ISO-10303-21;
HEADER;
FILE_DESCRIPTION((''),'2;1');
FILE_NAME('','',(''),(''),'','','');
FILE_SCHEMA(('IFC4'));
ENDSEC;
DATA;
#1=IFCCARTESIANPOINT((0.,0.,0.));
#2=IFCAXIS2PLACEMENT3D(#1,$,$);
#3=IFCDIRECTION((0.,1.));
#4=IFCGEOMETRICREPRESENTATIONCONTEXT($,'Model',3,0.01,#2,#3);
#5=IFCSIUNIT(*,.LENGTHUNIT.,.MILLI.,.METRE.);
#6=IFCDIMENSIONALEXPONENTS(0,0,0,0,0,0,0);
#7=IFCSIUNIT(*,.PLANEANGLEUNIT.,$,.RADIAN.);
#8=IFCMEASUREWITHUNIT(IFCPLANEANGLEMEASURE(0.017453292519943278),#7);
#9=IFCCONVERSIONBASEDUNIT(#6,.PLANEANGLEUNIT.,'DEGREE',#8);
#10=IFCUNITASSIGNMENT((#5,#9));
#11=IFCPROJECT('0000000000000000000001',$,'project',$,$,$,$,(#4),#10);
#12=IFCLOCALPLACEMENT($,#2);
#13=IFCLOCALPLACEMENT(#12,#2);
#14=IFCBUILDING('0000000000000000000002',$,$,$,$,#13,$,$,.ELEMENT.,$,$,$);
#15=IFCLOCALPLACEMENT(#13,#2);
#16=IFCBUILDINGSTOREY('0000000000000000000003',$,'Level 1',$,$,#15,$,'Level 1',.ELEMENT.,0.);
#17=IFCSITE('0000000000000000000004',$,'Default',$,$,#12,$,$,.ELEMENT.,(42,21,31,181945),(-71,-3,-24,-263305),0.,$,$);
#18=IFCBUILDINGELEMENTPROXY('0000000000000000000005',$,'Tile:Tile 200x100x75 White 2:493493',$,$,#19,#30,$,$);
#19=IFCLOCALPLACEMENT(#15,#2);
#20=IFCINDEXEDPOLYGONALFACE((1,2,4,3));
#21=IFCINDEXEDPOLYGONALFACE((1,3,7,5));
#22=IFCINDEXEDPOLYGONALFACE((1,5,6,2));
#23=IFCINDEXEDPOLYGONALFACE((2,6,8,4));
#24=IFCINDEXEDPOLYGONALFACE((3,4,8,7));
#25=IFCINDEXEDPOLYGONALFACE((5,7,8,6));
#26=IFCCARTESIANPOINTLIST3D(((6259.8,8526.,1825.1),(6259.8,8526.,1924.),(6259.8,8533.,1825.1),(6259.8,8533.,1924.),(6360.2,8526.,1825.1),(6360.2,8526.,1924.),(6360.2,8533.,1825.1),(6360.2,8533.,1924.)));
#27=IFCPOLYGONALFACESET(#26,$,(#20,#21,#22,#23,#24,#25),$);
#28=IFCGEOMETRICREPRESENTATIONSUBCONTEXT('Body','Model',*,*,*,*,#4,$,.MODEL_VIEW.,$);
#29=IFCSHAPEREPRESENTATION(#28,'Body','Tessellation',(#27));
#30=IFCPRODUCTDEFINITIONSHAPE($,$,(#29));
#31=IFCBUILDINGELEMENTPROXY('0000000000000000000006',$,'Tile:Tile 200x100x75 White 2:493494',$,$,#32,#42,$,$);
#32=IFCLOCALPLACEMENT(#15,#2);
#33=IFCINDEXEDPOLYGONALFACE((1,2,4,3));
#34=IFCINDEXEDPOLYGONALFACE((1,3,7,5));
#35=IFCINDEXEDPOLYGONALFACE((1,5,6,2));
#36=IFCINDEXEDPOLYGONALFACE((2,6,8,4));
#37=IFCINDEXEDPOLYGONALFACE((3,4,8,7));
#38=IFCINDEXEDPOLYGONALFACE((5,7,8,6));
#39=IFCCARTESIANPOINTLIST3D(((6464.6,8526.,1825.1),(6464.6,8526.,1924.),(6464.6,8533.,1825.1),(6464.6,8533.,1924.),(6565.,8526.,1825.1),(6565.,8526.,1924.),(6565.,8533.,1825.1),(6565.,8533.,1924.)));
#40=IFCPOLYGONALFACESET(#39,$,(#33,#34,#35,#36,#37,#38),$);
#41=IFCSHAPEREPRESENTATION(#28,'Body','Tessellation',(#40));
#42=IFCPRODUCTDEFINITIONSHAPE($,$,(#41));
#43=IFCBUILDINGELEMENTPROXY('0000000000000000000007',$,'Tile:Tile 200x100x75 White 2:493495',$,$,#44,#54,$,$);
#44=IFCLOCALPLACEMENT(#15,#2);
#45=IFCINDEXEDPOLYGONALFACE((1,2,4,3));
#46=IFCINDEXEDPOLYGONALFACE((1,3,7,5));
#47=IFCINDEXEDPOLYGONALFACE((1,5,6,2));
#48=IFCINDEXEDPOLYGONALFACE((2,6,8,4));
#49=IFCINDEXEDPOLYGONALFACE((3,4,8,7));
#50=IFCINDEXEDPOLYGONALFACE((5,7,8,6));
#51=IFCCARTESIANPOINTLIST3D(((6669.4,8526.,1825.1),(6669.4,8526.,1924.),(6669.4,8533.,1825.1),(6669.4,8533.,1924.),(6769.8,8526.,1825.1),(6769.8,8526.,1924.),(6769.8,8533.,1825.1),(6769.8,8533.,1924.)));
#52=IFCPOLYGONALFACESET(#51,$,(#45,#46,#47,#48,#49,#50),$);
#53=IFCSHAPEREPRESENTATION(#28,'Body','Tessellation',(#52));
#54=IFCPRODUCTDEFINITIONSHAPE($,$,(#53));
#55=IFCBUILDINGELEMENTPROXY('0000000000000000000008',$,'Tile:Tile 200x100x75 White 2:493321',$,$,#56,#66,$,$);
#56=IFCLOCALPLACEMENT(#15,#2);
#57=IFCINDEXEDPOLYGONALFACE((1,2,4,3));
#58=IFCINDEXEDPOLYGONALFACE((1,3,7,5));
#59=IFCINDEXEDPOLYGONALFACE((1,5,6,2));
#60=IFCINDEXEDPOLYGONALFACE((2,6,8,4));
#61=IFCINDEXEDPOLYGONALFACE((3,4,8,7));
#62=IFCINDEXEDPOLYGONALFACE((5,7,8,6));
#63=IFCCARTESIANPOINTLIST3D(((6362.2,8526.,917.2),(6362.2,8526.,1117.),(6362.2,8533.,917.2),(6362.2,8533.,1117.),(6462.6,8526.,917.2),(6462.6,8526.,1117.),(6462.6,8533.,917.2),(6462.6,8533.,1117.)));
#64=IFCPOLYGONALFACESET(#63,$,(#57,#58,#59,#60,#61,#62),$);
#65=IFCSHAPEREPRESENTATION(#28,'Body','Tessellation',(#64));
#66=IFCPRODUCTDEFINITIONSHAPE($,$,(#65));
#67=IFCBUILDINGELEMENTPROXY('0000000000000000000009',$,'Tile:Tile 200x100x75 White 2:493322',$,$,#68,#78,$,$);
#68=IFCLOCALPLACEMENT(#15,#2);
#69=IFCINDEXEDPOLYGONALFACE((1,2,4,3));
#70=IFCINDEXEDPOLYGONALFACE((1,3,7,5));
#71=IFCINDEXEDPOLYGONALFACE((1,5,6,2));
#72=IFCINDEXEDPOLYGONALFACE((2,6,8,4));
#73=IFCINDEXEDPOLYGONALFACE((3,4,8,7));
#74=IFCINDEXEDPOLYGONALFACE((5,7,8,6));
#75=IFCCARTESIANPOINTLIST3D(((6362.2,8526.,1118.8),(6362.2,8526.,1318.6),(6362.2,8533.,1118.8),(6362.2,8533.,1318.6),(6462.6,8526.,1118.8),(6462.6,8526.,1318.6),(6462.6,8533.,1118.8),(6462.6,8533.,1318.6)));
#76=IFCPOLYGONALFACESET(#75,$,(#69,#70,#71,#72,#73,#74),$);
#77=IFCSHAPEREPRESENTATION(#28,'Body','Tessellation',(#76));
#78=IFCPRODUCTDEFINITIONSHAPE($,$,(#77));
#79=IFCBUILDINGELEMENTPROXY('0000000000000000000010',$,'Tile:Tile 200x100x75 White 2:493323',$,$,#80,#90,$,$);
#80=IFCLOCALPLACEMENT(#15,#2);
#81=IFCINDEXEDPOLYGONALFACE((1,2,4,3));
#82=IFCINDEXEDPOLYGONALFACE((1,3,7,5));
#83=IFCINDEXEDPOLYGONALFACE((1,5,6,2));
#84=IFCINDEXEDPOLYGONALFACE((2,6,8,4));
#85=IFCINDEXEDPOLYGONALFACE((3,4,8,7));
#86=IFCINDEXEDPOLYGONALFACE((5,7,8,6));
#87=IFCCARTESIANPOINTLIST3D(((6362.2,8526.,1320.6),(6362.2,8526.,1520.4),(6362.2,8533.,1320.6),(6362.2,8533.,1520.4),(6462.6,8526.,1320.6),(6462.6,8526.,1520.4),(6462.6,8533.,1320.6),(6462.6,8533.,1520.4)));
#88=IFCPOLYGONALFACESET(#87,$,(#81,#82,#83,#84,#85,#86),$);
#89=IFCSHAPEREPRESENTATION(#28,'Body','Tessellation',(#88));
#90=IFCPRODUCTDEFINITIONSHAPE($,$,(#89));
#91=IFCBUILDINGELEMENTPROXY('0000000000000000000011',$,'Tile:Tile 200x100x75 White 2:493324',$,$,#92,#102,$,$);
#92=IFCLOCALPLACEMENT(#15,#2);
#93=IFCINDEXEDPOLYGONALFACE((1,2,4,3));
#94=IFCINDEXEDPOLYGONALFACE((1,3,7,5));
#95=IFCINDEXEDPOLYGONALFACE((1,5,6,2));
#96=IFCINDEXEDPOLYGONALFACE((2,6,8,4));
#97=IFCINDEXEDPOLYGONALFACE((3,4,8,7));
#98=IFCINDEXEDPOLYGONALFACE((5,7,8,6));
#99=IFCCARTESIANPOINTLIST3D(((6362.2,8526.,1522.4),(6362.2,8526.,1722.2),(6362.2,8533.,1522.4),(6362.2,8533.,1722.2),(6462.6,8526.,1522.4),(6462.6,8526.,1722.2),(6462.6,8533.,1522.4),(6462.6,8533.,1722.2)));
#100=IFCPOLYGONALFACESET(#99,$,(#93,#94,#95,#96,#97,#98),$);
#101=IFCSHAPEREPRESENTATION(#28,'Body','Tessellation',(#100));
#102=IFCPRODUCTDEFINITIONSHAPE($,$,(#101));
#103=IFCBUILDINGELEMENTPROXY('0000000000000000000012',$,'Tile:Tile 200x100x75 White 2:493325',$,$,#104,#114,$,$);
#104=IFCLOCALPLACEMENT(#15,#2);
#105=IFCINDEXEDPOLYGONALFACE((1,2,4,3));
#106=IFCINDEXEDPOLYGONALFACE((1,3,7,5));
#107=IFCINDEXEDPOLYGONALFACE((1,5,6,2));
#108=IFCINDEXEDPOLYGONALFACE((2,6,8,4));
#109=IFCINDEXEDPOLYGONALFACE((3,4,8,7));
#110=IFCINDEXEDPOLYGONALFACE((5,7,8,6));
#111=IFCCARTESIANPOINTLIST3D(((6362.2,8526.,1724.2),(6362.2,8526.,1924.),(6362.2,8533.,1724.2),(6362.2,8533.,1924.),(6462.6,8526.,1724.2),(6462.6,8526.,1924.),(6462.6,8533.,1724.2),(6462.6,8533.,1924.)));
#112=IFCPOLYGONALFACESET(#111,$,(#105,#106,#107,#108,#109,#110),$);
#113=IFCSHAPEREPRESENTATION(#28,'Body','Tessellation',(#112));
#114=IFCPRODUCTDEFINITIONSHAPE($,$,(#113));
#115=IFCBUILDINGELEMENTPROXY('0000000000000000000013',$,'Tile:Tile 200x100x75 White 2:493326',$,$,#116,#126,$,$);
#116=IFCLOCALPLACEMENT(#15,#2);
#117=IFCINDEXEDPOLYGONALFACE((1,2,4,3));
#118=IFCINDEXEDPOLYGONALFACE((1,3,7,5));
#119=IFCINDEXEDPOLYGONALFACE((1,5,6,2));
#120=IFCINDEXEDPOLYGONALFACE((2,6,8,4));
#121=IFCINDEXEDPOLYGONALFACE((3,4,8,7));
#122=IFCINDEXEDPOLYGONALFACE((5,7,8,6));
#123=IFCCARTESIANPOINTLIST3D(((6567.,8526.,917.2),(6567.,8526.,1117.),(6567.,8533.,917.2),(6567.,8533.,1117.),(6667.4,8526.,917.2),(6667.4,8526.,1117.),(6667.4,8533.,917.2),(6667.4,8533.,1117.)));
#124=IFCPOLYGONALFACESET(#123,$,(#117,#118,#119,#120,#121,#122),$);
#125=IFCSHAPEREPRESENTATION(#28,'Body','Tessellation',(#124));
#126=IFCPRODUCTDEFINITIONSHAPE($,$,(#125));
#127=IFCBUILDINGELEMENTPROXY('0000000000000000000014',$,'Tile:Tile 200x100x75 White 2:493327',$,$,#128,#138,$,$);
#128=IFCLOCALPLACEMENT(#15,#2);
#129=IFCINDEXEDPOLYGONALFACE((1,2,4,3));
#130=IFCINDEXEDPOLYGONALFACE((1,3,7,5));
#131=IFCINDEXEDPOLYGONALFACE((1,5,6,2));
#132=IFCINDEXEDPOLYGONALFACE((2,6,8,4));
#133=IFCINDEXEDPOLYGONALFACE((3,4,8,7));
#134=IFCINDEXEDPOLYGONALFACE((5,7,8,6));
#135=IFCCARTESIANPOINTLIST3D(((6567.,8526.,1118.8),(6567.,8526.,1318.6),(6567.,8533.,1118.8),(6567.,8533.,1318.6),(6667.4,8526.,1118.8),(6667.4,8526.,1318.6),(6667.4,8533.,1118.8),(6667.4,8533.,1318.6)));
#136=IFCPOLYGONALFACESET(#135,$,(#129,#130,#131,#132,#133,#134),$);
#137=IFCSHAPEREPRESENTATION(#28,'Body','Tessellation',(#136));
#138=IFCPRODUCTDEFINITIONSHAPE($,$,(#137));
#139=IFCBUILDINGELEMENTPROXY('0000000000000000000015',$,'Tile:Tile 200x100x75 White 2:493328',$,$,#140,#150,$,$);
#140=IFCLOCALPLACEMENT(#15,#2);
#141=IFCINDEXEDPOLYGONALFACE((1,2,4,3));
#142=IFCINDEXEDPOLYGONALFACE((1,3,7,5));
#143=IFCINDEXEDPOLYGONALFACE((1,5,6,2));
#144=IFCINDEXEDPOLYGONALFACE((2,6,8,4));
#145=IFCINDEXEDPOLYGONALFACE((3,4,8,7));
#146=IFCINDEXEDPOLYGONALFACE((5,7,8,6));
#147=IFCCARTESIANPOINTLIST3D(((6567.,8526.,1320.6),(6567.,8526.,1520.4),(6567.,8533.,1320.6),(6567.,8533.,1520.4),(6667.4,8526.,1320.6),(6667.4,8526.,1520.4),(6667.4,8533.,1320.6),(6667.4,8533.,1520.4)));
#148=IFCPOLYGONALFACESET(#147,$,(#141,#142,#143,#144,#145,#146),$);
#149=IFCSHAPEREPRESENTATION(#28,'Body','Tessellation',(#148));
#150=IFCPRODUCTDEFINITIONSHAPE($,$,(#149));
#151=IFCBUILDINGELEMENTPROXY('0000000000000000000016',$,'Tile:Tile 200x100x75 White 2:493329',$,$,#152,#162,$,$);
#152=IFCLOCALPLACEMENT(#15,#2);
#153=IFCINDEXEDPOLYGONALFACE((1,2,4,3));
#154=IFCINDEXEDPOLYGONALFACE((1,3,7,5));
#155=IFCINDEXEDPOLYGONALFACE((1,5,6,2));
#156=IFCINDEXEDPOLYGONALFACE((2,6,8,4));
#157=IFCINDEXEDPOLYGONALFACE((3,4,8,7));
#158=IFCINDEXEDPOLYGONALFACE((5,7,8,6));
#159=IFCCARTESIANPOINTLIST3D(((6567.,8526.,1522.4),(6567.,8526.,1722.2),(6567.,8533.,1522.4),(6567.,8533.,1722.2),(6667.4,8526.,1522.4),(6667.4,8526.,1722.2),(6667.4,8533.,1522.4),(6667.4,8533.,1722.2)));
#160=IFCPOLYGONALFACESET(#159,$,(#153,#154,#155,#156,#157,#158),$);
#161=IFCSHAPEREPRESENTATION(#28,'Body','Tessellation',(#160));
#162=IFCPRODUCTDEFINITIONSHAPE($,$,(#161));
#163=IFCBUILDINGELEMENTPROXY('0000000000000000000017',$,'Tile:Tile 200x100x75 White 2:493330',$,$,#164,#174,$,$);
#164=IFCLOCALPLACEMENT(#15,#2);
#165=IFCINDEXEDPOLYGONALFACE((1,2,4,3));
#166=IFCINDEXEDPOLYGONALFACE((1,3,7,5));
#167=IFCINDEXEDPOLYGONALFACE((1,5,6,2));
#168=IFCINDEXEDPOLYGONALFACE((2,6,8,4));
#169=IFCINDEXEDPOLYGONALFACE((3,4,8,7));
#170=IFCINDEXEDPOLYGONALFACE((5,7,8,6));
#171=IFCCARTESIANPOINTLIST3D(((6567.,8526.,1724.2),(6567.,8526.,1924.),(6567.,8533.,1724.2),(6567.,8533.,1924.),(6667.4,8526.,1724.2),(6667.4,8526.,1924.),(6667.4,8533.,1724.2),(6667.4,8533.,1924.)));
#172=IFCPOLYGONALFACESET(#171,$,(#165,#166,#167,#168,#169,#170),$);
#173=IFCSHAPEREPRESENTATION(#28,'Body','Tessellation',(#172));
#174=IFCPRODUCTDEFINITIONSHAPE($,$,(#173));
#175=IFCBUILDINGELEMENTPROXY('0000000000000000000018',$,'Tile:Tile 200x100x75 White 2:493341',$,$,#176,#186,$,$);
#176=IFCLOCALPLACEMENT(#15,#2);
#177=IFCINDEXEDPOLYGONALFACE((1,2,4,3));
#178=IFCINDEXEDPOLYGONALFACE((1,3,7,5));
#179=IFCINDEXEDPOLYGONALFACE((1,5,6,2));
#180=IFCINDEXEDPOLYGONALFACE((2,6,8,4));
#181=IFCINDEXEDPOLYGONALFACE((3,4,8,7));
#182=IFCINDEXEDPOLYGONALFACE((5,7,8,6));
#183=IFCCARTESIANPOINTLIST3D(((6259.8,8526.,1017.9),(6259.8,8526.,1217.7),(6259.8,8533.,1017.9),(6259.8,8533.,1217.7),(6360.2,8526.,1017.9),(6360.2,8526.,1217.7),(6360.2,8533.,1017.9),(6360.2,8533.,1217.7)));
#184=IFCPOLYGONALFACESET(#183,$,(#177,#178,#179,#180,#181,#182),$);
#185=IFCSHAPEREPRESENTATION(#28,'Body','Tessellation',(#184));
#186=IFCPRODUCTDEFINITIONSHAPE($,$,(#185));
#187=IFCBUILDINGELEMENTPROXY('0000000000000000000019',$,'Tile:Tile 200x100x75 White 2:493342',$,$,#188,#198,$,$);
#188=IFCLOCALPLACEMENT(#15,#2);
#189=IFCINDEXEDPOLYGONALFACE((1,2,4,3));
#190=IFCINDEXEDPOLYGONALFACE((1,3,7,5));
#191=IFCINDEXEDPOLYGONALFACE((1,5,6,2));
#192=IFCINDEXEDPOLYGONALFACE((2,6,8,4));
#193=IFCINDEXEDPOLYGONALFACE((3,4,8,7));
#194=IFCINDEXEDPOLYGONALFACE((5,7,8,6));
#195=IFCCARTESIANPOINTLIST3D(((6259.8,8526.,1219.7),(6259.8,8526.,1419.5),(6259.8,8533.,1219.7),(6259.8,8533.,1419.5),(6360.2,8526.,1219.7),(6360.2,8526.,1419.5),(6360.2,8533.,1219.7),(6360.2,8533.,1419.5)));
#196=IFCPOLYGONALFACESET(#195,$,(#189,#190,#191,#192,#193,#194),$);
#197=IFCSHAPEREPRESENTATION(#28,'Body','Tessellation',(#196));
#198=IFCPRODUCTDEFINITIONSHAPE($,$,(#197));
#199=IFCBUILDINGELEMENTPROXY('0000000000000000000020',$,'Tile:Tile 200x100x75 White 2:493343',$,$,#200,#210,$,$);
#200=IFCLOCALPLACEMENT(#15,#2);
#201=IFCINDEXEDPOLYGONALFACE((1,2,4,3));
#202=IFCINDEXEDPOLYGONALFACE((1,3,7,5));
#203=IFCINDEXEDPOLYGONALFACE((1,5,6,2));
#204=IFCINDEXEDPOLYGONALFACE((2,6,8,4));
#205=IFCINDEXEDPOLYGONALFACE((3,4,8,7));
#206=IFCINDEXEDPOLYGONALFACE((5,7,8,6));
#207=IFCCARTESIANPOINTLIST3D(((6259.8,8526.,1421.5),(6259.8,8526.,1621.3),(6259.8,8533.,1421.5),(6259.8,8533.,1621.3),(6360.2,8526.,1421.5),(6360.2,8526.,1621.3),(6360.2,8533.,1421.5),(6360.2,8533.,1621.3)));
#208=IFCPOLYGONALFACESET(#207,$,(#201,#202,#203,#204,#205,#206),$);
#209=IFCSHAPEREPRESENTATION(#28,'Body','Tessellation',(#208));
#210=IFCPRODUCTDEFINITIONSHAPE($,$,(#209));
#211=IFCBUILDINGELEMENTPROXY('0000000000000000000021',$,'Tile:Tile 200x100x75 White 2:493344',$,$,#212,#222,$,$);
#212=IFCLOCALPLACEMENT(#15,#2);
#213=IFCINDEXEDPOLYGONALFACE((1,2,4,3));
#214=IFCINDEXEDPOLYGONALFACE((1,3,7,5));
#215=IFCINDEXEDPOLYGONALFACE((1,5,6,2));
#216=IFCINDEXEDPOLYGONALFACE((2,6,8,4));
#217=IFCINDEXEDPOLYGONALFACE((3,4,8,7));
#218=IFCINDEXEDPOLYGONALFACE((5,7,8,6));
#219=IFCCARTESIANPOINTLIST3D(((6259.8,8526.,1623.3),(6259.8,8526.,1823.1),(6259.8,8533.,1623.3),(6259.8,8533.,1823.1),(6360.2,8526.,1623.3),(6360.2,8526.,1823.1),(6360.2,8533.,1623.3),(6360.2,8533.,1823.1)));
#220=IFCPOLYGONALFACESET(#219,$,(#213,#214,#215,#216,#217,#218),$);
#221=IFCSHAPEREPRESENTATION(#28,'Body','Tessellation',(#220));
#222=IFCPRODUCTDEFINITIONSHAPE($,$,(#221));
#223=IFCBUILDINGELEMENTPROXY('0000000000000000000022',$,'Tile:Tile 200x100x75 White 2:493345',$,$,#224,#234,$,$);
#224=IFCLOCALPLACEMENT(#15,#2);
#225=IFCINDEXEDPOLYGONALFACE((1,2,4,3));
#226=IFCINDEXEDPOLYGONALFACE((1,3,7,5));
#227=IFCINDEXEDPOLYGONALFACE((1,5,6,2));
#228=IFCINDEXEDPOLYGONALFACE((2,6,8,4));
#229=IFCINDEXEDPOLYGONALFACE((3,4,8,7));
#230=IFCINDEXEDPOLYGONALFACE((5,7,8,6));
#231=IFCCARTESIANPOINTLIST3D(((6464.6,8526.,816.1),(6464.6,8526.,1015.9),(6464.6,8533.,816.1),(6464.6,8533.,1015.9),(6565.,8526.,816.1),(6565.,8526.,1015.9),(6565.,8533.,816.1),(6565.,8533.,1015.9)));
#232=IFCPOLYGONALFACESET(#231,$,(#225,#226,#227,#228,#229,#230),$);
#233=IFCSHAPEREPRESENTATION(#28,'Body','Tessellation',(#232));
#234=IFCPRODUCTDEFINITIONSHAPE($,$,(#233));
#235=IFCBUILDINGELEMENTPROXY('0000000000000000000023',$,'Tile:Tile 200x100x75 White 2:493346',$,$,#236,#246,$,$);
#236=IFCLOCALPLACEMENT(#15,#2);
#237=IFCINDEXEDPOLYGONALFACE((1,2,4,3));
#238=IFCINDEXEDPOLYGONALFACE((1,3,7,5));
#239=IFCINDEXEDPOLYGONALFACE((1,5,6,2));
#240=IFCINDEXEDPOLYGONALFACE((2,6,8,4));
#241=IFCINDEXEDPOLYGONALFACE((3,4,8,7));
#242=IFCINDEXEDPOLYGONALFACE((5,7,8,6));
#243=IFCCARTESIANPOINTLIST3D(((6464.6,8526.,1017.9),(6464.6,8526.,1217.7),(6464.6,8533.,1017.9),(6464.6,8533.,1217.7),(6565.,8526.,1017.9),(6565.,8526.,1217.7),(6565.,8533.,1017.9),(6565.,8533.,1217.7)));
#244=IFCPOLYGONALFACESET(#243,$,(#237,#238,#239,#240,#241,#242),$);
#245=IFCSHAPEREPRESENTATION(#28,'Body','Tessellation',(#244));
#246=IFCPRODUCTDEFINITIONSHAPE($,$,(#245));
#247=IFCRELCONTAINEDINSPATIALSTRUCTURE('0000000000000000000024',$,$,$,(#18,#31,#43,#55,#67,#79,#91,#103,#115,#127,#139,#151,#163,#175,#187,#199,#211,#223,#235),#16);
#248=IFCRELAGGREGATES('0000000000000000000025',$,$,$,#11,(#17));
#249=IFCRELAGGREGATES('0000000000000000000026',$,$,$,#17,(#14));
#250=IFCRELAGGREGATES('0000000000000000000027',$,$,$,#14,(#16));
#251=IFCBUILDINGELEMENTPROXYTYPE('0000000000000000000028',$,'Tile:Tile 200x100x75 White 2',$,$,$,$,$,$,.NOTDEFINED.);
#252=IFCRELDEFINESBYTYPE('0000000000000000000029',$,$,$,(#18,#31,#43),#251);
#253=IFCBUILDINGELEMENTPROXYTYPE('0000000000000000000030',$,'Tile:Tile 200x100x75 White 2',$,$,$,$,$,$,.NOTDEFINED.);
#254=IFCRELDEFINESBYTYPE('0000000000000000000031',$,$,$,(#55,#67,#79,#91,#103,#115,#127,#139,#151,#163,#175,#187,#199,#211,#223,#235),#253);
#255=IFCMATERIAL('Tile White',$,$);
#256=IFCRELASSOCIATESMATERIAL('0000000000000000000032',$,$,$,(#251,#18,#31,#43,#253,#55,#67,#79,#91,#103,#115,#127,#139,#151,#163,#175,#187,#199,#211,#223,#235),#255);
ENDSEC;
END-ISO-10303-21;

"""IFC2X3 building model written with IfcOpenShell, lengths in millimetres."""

from ifc_helpers import new_model, entity, si_unit, converted_unit, direction, frame, frame_2d, origin, origin_2d_with_axis, place, context, subcontext, project, spatial, rectangle, extrude, source, transform, mapped, material, type_object, type_shapes, element, save


model = new_model("IFC2X3")

# Units and contexts
model_context = context("Model", 3, precision=0.01, world=origin(), true_north=direction((0.0, 1.0)))
body_context = subcontext(model_context, "Body", "Model", "MODEL_VIEW")
ifc_project = project(units=[si_unit("LENGTHUNIT", "METRE", prefix="MILLI"), converted_unit("PLANEANGLEUNIT", "DEGREE", entity("IfcPlaneAngleMeasure", 0.017453292519943278), si_unit("PLANEANGLEUNIT", "RADIAN"), dimensions=[0, 0, 0, 0, 0, 0, 0])], contexts=[model_context])

# Site, building, storey
site_placement = place(None, origin())
site = spatial("IfcSite", under=ifc_project, at=site_placement, Name="Default", CompositionType="ELEMENT", RefLatitude=(42, 21, 31, 181945), RefLongitude=(-71, -3, -24, -263305), RefElevation=0.0)
building_placement = place(site_placement, origin())
building = spatial("IfcBuilding", under=site, at=building_placement, CompositionType="ELEMENT")
storey_placement = place(building_placement, origin())
storey = spatial("IfcBuildingStorey", under=building, at=storey_placement, Name="Level 1", LongName="Level 1", CompositionType="ELEMENT", Elevation=0.0)

# Building element proxies
ifc_material = material(Name="Tile White")
building_element_proxy_type_1 = type_object("IfcBuildingElementProxyType", Name="Tile:Tile 200x100x75 White 2", PredefinedType="NOTDEFINED", material=ifc_material)
shared_shape_1 = source(origin(), body_context, "Body", "SweptSolid", [
    extrude(rectangle(XDim=98.9, YDim=100.4, at=origin_2d_with_axis()), frame((-50.2, -49.5, 0.0), z_axis=(0.0, 0.0, 1.0), x_axis=(0.0, -1.0, 0.0)), (0.0, 0.0, 1.0), 7.0),
])
type_shapes(building_element_proxy_type_1, [shared_shape_1])
for number, where, z_axis, x_axis, name in (
    (1, (6360.2, 8533.0, 1924.0), (0.0, -1.0, 0.0), (1.0, 0.0, 0.0), "Tile:Tile 200x100x75 White 2:493493"),
    (2, (6565.0, 8533.0, 1924.0), (0.0, -1.0, 0.0), (1.0, 0.0, 0.0), "Tile:Tile 200x100x75 White 2:493494"),
    (3, (6769.8, 8533.0, 1924.0), (0.0, -1.0, 0.0), (1.0, 0.0, 0.0), "Tile:Tile 200x100x75 White 2:493495"),
):
    element("IfcBuildingElementProxy", number, at=place(storey_placement, frame(where, z_axis=z_axis, x_axis=x_axis)), inside=storey, type_object=building_element_proxy_type_1, material=ifc_material, Name=name, context=body_context, shape_type="MappedRepresentation", body=[
        mapped(shared_shape_1, transform((0.0, 0.0, 0.0), scale=1.0)),
    ])
building_element_proxy_type_2 = type_object("IfcBuildingElementProxyType", Name="Tile:Tile 200x100x75 White 2", PredefinedType="NOTDEFINED", material=ifc_material)
shared_shape_2 = source(origin(), body_context, "Body", "SweptSolid", [
    extrude(rectangle(XDim=199.8, YDim=100.4, at=frame_2d((0.0, 0.0), x_axis=(1.0, 0.0))), frame((-50.2, -99.9, 0.0), z_axis=(0.0, 0.0, 1.0), x_axis=(0.0, -1.0, 0.0)), (0.0, 0.0, 1.0), 7.0),
])
type_shapes(building_element_proxy_type_2, [shared_shape_2])
for number, where, z_axis, x_axis, name in (
    (4, (6462.6, 8533.0, 1117.0), (0.0, -1.0, 0.0), (1.0, 0.0, 0.0), "Tile:Tile 200x100x75 White 2:493321"),
    (5, (6462.6, 8533.0, 1318.6), (0.0, -1.0, 0.0), (1.0, 0.0, 0.0), "Tile:Tile 200x100x75 White 2:493322"),
    (6, (6462.6, 8533.0, 1520.4), (0.0, -1.0, 0.0), (1.0, 0.0, 0.0), "Tile:Tile 200x100x75 White 2:493323"),
    (7, (6462.6, 8533.0, 1722.2), (0.0, -1.0, 0.0), (1.0, 0.0, 0.0), "Tile:Tile 200x100x75 White 2:493324"),
    (8, (6462.6, 8533.0, 1924.0), (0.0, -1.0, 0.0), (1.0, 0.0, 0.0), "Tile:Tile 200x100x75 White 2:493325"),
    (9, (6667.4, 8533.0, 1117.0), (0.0, -1.0, 0.0), (1.0, 0.0, 0.0), "Tile:Tile 200x100x75 White 2:493326"),
    (10, (6667.4, 8533.0, 1318.6), (0.0, -1.0, 0.0), (1.0, 0.0, 0.0), "Tile:Tile 200x100x75 White 2:493327"),
    (11, (6667.4, 8533.0, 1520.4), (0.0, -1.0, 0.0), (1.0, 0.0, 0.0), "Tile:Tile 200x100x75 White 2:493328"),
    (12, (6667.4, 8533.0, 1722.2), (0.0, -1.0, 0.0), (1.0, 0.0, 0.0), "Tile:Tile 200x100x75 White 2:493329"),
    (13, (6667.4, 8533.0, 1924.0), (0.0, -1.0, 0.0), (1.0, 0.0, 0.0), "Tile:Tile 200x100x75 White 2:493330"),
    (14, (6360.2, 8533.0, 1217.7), (0.0, -1.0, 0.0), (1.0, 0.0, 0.0), "Tile:Tile 200x100x75 White 2:493341"),
    (15, (6360.2, 8533.0, 1419.5), (0.0, -1.0, 0.0), (1.0, 0.0, 0.0), "Tile:Tile 200x100x75 White 2:493342"),
    (16, (6360.2, 8533.0, 1621.3), (0.0, -1.0, 0.0), (1.0, 0.0, 0.0), "Tile:Tile 200x100x75 White 2:493343"),
    (17, (6360.2, 8533.0, 1823.1), (0.0, -1.0, 0.0), (1.0, 0.0, 0.0), "Tile:Tile 200x100x75 White 2:493344"),
    (18, (6565.0, 8533.0, 1015.9), (0.0, -1.0, 0.0), (1.0, 0.0, 0.0), "Tile:Tile 200x100x75 White 2:493345"),
    (19, (6565.0, 8533.0, 1217.7), (0.0, -1.0, 0.0), (1.0, 0.0, 0.0), "Tile:Tile 200x100x75 White 2:493346"),
):
    element("IfcBuildingElementProxy", number, at=place(storey_placement, frame(where, z_axis=z_axis, x_axis=x_axis)), inside=storey, type_object=building_element_proxy_type_2, material=ifc_material, Name=name, context=body_context, shape_type="MappedRepresentation", body=[
        mapped(shared_shape_2, transform((0.0, 0.0, 0.0), scale=1.0)),
    ])

save(model, "model.ifc")
